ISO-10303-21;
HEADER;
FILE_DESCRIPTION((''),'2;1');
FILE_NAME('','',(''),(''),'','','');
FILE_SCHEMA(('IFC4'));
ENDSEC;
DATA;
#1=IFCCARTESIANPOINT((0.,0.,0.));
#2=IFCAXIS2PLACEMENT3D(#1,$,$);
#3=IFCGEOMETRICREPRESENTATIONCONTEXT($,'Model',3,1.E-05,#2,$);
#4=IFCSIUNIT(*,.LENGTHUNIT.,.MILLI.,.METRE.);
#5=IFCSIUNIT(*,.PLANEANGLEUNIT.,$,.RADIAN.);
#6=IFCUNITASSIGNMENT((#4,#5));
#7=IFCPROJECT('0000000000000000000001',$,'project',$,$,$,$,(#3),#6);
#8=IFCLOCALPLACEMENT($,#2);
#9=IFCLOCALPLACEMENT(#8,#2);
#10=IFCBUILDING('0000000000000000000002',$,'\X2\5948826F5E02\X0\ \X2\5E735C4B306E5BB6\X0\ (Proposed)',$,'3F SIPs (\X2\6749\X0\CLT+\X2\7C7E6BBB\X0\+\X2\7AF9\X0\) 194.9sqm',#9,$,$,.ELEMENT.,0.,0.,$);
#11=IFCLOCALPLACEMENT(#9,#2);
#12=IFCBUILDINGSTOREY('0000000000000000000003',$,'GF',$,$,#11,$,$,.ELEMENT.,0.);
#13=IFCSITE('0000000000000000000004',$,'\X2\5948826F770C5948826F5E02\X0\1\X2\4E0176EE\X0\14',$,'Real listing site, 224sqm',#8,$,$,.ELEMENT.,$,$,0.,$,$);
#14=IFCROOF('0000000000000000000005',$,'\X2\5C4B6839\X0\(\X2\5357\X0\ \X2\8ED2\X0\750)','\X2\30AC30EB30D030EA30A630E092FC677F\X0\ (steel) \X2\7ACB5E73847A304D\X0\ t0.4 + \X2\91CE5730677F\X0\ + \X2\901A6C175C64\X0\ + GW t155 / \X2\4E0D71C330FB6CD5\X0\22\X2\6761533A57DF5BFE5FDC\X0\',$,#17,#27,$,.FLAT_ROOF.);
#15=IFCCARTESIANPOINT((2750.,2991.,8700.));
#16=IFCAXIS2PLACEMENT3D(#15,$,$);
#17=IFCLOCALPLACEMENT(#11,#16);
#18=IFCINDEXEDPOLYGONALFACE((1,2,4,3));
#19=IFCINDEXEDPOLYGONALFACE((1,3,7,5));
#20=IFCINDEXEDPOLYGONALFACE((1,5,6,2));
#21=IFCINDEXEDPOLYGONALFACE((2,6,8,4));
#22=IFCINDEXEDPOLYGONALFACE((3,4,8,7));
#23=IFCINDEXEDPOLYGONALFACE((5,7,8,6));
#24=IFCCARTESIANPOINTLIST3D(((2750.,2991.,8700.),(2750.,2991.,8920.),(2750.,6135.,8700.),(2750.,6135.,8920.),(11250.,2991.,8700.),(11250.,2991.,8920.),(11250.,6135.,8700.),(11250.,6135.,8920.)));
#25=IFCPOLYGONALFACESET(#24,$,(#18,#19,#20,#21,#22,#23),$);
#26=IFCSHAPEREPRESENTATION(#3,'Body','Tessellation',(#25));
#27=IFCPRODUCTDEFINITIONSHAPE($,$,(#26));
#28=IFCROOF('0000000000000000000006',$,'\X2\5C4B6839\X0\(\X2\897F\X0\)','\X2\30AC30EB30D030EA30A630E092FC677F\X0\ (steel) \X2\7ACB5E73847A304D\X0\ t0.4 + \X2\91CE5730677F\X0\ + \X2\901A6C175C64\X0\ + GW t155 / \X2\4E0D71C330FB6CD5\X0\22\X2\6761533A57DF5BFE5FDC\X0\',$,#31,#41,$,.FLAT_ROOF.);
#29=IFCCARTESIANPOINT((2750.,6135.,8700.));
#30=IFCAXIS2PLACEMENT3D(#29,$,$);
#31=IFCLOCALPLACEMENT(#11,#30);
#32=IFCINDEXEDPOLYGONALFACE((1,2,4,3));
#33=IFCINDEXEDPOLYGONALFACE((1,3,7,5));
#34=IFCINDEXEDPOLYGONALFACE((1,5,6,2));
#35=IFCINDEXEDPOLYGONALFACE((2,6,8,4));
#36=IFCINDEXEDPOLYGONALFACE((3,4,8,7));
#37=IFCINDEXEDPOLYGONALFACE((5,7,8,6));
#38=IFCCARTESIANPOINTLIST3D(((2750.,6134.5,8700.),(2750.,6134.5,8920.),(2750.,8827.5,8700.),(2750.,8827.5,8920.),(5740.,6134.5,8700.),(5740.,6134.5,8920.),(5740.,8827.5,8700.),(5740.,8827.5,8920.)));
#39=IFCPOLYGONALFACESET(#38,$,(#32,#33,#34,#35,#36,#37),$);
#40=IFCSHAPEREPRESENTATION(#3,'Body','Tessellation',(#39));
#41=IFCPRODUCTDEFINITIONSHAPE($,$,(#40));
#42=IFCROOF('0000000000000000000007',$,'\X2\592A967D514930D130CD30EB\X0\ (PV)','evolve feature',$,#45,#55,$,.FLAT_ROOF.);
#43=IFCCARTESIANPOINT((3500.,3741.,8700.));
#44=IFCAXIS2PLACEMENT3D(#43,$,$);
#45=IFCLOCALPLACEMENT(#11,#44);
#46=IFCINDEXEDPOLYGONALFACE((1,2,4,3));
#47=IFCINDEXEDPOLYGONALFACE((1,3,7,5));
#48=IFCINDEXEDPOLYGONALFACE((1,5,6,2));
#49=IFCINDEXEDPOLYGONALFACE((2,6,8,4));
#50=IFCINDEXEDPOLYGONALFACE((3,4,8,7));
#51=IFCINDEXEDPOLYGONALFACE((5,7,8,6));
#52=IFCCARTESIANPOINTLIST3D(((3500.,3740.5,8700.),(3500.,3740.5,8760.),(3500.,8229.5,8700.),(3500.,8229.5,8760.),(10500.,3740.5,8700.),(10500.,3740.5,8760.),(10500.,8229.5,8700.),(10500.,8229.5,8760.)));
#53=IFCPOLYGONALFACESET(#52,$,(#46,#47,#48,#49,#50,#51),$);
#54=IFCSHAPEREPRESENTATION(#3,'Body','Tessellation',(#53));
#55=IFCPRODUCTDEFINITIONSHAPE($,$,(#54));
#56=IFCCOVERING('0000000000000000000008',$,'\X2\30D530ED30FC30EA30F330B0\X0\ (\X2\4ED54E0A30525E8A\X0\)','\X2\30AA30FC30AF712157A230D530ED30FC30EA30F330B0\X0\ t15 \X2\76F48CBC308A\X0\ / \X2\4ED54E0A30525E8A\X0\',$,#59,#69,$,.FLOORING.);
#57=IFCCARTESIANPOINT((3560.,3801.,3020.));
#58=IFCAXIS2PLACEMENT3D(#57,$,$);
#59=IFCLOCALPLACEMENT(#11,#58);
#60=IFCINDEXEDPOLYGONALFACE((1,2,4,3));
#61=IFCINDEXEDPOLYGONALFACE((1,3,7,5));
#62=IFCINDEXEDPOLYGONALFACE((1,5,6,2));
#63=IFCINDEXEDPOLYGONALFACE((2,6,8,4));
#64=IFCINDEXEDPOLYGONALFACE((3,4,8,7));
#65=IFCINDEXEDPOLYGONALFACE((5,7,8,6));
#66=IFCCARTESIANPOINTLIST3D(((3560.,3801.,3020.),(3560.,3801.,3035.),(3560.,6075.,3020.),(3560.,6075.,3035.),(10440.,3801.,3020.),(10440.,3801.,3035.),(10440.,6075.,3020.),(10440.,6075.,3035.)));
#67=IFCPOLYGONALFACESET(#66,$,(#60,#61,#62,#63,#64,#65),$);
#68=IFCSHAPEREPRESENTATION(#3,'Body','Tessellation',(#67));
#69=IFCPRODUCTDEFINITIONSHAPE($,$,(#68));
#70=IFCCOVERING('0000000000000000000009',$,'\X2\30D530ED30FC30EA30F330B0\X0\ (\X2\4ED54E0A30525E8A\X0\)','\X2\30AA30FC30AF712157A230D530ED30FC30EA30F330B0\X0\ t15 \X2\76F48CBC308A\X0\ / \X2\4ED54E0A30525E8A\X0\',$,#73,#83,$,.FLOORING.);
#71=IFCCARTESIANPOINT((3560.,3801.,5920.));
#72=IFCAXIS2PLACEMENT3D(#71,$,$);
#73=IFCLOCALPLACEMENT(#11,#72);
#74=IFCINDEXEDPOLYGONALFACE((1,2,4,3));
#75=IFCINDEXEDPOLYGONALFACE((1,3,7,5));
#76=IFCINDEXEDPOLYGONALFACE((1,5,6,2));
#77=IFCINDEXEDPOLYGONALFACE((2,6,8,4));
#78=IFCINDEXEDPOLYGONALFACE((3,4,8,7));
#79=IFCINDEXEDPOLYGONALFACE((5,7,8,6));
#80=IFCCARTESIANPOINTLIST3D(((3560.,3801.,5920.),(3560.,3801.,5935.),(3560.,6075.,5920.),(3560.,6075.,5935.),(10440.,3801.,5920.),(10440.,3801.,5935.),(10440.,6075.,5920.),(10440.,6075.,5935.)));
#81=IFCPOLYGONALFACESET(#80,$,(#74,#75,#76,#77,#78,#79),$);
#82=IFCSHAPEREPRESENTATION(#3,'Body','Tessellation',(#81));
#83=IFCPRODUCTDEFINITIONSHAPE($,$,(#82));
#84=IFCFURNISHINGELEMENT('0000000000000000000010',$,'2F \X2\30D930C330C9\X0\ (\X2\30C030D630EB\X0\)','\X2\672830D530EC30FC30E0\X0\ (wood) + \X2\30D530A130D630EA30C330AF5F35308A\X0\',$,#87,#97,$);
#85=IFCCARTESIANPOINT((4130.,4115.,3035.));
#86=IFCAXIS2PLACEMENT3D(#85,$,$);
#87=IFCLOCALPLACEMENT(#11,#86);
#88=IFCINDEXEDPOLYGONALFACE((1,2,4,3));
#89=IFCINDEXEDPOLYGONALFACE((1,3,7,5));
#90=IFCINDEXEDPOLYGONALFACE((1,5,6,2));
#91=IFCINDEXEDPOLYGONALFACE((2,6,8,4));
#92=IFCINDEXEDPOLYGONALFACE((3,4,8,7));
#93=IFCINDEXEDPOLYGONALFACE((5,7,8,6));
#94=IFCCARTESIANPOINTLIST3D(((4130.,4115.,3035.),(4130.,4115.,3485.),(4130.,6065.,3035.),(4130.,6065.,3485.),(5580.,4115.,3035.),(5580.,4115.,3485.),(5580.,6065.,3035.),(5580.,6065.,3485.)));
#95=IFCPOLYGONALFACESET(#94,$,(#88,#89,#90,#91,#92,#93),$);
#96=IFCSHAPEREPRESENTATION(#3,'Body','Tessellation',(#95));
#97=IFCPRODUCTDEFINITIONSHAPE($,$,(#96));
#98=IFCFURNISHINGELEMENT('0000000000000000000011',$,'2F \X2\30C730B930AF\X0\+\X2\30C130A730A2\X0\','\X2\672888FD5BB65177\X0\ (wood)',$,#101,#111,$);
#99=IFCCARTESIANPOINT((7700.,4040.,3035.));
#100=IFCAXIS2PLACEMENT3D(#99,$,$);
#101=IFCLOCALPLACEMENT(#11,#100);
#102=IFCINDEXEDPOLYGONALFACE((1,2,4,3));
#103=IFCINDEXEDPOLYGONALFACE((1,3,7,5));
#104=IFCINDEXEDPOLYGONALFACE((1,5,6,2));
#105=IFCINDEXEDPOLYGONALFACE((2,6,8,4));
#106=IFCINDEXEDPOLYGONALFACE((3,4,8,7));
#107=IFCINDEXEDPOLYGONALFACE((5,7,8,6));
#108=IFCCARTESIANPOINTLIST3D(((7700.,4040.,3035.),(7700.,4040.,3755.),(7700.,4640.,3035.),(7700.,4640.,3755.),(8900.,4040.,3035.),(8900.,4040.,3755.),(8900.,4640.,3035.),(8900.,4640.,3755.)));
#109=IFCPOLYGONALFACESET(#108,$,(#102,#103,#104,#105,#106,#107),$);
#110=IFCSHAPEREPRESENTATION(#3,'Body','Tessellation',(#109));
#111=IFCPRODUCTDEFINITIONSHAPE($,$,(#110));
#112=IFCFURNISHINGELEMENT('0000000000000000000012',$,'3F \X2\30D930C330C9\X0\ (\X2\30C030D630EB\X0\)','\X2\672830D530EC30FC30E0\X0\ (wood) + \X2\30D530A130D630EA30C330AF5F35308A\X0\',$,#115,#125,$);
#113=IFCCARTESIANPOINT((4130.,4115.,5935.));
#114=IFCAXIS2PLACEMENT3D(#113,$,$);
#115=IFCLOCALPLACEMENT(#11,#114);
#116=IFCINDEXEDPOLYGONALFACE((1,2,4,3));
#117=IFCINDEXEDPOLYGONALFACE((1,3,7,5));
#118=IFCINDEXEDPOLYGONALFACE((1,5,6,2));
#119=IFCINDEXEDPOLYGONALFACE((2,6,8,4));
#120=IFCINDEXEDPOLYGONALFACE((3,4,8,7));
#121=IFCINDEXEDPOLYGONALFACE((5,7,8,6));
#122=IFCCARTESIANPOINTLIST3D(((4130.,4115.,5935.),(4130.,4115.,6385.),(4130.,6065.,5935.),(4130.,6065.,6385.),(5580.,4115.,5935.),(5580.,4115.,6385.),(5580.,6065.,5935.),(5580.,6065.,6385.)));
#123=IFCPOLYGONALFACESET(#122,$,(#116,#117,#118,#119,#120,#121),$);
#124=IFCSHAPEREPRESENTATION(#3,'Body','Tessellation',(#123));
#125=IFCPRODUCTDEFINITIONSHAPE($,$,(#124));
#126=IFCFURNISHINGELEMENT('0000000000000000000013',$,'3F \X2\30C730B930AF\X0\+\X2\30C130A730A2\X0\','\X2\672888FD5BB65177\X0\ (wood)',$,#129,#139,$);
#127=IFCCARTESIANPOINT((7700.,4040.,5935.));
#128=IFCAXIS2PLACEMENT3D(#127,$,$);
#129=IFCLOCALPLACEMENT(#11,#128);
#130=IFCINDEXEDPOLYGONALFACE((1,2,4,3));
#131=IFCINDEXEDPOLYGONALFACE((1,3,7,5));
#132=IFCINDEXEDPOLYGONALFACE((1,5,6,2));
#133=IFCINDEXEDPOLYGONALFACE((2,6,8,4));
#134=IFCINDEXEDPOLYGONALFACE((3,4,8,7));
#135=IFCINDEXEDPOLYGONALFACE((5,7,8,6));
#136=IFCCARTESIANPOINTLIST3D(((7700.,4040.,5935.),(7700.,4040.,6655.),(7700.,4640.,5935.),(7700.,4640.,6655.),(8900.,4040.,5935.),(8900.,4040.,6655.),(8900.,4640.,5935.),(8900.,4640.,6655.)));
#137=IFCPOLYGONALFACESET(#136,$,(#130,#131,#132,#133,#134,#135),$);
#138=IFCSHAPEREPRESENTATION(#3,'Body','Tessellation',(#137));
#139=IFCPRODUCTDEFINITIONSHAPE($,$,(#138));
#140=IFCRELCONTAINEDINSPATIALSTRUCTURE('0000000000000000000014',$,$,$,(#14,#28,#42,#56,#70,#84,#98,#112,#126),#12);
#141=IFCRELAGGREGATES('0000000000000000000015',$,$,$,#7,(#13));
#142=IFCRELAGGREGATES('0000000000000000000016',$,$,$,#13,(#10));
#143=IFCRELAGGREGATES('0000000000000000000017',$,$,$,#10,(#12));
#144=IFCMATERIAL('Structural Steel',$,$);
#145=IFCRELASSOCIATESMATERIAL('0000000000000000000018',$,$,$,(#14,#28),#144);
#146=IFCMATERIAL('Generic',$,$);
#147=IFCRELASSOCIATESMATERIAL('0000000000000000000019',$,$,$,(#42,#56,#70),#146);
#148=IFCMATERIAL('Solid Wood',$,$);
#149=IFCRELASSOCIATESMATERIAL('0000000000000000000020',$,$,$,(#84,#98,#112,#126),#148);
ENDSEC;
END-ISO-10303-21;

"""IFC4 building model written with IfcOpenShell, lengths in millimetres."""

from ifc_helpers import new_model, si_unit, frame, frame_2d, origin, place, context, project, spatial, rectangle, extrude, material, element, save


model = new_model("IFC4")

# Units and contexts
model_context = context("Model", 3, precision=1e-05, world=origin())
ifc_project = project(units=[si_unit("LENGTHUNIT", "METRE", prefix="MILLI"), si_unit("PLANEANGLEUNIT", "RADIAN")], contexts=[model_context])

# Site, building, storey
site_placement = place(None, origin())
site = spatial("IfcSite", under=ifc_project, at=site_placement, Name="奈良県奈良市1丁目14", ObjectType="Real listing site, 224sqm", CompositionType="ELEMENT", RefElevation=0.0)
building_placement = place(site_placement, origin())
building = spatial("IfcBuilding", under=site, at=building_placement, Name="奈良市 平屋の家 (Proposed)", ObjectType="3F SIPs (杉CLT+籾殻+竹) 194.9sqm", CompositionType="ELEMENT", ElevationOfRefHeight=0.0, ElevationOfTerrain=0.0)
storey_placement = place(building_placement, origin())
storey = spatial("IfcBuildingStorey", under=building, at=storey_placement, Name="GF", CompositionType="ELEMENT", Elevation=0.0)

# Shared definitions
ifc_material_1 = material(Name="Solid Wood")

# Roofs
ifc_material_2 = material(Name="Structural Steel")
roof_1_placement = place(storey_placement, frame((2750.0, 2991.0, 8700.0)))
element("IfcRoof", 1, at=roof_1_placement, inside=storey, material=ifc_material_2, Name="屋根(南 軒750)", Description="ガルバリウム鋼板 (steel) 立平葺き t0.4 + 野地板 + 通気層 + GW t155 / 不燃・法22条区域対応", PredefinedType="FLAT_ROOF", context=model_context, shape_type="SweptSolid", body=[
    extrude(rectangle(XDim=8500.0, YDim=3144.0, at=frame_2d((4250.0, 1572.0))), frame((2750.0, 2991.0, 8700.0)), (0.0, 0.0, 1.0), 220.0),
])
roof_2_placement = place(storey_placement, frame((2750.0, 6135.0, 8700.0)))
element("IfcRoof", 2, at=roof_2_placement, inside=storey, material=ifc_material_2, Name="屋根(西)", Description="ガルバリウム鋼板 (steel) 立平葺き t0.4 + 野地板 + 通気層 + GW t155 / 不燃・法22条区域対応", PredefinedType="FLAT_ROOF", context=model_context, shape_type="SweptSolid", body=[
    extrude(rectangle(XDim=2990.0, YDim=2693.0, at=frame_2d((1495.0, 1346.0))), frame((2750.0, 6135.0, 8700.0)), (0.0, 0.0, 1.0), 220.0),
])
ifc_material_3 = material(Name="Generic")
roof_3_placement = place(storey_placement, frame((3500.0, 3741.0, 8700.0)))
element("IfcRoof", 3, at=roof_3_placement, inside=storey, material=ifc_material_3, Name="太陽光パネル (PV)", Description="evolve feature", PredefinedType="FLAT_ROOF", context=model_context, shape_type="SweptSolid", body=[
    extrude(rectangle(XDim=7000.0, YDim=4489.0, at=frame_2d((3500.0, 2244.0))), frame((3500.0, 3741.0, 8700.0)), (0.0, 0.0, 1.0), 60.0),
])

# Coverings
covering_1_placement = place(storey_placement, frame((3560.0, 3801.0, 3020.0)))
element("IfcCovering", 4, at=covering_1_placement, inside=storey, material=ifc_material_3, Name="フローリング (仕上げ床)", Description="オーク無垢フローリング t15 直貼り / 仕上げ床", PredefinedType="FLOORING", context=model_context, shape_type="SweptSolid", body=[
    extrude(rectangle(XDim=6880.0, YDim=2274.0, at=frame_2d((3440.0, 1137.0))), frame((3560.0, 3801.0, 3020.0)), (0.0, 0.0, 1.0), 15.0),
])
covering_2_placement = place(storey_placement, frame((3560.0, 3801.0, 5920.0)))
element("IfcCovering", 5, at=covering_2_placement, inside=storey, material=ifc_material_3, Name="フローリング (仕上げ床)", Description="オーク無垢フローリング t15 直貼り / 仕上げ床", PredefinedType="FLOORING", context=model_context, shape_type="SweptSolid", body=[
    extrude(rectangle(XDim=6880.0, YDim=2274.0, at=frame_2d((3440.0, 1137.0))), frame((3560.0, 3801.0, 5920.0)), (0.0, 0.0, 1.0), 15.0),
])

# Furnishing elements
furnishing_1_placement = place(storey_placement, frame((4130.0, 4115.0, 3035.0)))
element("IfcFurnishingElement", 6, at=furnishing_1_placement, inside=storey, material=ifc_material_1, Name="2F ベッド (ダブル)", Description="木フレーム (wood) + ファブリック張り", context=model_context, shape_type="SweptSolid", body=[
    extrude(rectangle(XDim=1450.0, YDim=1950.0, at=frame_2d((725.0, 975.0))), frame((4130.0, 4115.0, 3035.0)), (0.0, 0.0, 1.0), 450.0),
])
furnishing_2_placement = place(storey_placement, frame((7700.0, 4040.0, 3035.0)))
element("IfcFurnishingElement", 7, at=furnishing_2_placement, inside=storey, material=ifc_material_1, Name="2F デスク+チェア", Description="木製家具 (wood)", context=model_context, shape_type="SweptSolid", body=[
    extrude(rectangle(XDim=1200.0, YDim=600.0, at=frame_2d((600.0, 300.0))), frame((7700.0, 4040.0, 3035.0)), (0.0, 0.0, 1.0), 720.0),
])
furnishing_3_placement = place(storey_placement, frame((4130.0, 4115.0, 5935.0)))
element("IfcFurnishingElement", 8, at=furnishing_3_placement, inside=storey, material=ifc_material_1, Name="3F ベッド (ダブル)", Description="木フレーム (wood) + ファブリック張り", context=model_context, shape_type="SweptSolid", body=[
    extrude(rectangle(XDim=1450.0, YDim=1950.0, at=frame_2d((725.0, 975.0))), frame((4130.0, 4115.0, 5935.0)), (0.0, 0.0, 1.0), 450.0),
])
furnishing_4_placement = place(storey_placement, frame((7700.0, 4040.0, 5935.0)))
element("IfcFurnishingElement", 9, at=furnishing_4_placement, inside=storey, material=ifc_material_1, Name="3F デスク+チェア", Description="木製家具 (wood)", context=model_context, shape_type="SweptSolid", body=[
    extrude(rectangle(XDim=1200.0, YDim=600.0, at=frame_2d((600.0, 300.0))), frame((7700.0, 4040.0, 5935.0)), (0.0, 0.0, 1.0), 720.0),
])

save(model, "model.ifc")
